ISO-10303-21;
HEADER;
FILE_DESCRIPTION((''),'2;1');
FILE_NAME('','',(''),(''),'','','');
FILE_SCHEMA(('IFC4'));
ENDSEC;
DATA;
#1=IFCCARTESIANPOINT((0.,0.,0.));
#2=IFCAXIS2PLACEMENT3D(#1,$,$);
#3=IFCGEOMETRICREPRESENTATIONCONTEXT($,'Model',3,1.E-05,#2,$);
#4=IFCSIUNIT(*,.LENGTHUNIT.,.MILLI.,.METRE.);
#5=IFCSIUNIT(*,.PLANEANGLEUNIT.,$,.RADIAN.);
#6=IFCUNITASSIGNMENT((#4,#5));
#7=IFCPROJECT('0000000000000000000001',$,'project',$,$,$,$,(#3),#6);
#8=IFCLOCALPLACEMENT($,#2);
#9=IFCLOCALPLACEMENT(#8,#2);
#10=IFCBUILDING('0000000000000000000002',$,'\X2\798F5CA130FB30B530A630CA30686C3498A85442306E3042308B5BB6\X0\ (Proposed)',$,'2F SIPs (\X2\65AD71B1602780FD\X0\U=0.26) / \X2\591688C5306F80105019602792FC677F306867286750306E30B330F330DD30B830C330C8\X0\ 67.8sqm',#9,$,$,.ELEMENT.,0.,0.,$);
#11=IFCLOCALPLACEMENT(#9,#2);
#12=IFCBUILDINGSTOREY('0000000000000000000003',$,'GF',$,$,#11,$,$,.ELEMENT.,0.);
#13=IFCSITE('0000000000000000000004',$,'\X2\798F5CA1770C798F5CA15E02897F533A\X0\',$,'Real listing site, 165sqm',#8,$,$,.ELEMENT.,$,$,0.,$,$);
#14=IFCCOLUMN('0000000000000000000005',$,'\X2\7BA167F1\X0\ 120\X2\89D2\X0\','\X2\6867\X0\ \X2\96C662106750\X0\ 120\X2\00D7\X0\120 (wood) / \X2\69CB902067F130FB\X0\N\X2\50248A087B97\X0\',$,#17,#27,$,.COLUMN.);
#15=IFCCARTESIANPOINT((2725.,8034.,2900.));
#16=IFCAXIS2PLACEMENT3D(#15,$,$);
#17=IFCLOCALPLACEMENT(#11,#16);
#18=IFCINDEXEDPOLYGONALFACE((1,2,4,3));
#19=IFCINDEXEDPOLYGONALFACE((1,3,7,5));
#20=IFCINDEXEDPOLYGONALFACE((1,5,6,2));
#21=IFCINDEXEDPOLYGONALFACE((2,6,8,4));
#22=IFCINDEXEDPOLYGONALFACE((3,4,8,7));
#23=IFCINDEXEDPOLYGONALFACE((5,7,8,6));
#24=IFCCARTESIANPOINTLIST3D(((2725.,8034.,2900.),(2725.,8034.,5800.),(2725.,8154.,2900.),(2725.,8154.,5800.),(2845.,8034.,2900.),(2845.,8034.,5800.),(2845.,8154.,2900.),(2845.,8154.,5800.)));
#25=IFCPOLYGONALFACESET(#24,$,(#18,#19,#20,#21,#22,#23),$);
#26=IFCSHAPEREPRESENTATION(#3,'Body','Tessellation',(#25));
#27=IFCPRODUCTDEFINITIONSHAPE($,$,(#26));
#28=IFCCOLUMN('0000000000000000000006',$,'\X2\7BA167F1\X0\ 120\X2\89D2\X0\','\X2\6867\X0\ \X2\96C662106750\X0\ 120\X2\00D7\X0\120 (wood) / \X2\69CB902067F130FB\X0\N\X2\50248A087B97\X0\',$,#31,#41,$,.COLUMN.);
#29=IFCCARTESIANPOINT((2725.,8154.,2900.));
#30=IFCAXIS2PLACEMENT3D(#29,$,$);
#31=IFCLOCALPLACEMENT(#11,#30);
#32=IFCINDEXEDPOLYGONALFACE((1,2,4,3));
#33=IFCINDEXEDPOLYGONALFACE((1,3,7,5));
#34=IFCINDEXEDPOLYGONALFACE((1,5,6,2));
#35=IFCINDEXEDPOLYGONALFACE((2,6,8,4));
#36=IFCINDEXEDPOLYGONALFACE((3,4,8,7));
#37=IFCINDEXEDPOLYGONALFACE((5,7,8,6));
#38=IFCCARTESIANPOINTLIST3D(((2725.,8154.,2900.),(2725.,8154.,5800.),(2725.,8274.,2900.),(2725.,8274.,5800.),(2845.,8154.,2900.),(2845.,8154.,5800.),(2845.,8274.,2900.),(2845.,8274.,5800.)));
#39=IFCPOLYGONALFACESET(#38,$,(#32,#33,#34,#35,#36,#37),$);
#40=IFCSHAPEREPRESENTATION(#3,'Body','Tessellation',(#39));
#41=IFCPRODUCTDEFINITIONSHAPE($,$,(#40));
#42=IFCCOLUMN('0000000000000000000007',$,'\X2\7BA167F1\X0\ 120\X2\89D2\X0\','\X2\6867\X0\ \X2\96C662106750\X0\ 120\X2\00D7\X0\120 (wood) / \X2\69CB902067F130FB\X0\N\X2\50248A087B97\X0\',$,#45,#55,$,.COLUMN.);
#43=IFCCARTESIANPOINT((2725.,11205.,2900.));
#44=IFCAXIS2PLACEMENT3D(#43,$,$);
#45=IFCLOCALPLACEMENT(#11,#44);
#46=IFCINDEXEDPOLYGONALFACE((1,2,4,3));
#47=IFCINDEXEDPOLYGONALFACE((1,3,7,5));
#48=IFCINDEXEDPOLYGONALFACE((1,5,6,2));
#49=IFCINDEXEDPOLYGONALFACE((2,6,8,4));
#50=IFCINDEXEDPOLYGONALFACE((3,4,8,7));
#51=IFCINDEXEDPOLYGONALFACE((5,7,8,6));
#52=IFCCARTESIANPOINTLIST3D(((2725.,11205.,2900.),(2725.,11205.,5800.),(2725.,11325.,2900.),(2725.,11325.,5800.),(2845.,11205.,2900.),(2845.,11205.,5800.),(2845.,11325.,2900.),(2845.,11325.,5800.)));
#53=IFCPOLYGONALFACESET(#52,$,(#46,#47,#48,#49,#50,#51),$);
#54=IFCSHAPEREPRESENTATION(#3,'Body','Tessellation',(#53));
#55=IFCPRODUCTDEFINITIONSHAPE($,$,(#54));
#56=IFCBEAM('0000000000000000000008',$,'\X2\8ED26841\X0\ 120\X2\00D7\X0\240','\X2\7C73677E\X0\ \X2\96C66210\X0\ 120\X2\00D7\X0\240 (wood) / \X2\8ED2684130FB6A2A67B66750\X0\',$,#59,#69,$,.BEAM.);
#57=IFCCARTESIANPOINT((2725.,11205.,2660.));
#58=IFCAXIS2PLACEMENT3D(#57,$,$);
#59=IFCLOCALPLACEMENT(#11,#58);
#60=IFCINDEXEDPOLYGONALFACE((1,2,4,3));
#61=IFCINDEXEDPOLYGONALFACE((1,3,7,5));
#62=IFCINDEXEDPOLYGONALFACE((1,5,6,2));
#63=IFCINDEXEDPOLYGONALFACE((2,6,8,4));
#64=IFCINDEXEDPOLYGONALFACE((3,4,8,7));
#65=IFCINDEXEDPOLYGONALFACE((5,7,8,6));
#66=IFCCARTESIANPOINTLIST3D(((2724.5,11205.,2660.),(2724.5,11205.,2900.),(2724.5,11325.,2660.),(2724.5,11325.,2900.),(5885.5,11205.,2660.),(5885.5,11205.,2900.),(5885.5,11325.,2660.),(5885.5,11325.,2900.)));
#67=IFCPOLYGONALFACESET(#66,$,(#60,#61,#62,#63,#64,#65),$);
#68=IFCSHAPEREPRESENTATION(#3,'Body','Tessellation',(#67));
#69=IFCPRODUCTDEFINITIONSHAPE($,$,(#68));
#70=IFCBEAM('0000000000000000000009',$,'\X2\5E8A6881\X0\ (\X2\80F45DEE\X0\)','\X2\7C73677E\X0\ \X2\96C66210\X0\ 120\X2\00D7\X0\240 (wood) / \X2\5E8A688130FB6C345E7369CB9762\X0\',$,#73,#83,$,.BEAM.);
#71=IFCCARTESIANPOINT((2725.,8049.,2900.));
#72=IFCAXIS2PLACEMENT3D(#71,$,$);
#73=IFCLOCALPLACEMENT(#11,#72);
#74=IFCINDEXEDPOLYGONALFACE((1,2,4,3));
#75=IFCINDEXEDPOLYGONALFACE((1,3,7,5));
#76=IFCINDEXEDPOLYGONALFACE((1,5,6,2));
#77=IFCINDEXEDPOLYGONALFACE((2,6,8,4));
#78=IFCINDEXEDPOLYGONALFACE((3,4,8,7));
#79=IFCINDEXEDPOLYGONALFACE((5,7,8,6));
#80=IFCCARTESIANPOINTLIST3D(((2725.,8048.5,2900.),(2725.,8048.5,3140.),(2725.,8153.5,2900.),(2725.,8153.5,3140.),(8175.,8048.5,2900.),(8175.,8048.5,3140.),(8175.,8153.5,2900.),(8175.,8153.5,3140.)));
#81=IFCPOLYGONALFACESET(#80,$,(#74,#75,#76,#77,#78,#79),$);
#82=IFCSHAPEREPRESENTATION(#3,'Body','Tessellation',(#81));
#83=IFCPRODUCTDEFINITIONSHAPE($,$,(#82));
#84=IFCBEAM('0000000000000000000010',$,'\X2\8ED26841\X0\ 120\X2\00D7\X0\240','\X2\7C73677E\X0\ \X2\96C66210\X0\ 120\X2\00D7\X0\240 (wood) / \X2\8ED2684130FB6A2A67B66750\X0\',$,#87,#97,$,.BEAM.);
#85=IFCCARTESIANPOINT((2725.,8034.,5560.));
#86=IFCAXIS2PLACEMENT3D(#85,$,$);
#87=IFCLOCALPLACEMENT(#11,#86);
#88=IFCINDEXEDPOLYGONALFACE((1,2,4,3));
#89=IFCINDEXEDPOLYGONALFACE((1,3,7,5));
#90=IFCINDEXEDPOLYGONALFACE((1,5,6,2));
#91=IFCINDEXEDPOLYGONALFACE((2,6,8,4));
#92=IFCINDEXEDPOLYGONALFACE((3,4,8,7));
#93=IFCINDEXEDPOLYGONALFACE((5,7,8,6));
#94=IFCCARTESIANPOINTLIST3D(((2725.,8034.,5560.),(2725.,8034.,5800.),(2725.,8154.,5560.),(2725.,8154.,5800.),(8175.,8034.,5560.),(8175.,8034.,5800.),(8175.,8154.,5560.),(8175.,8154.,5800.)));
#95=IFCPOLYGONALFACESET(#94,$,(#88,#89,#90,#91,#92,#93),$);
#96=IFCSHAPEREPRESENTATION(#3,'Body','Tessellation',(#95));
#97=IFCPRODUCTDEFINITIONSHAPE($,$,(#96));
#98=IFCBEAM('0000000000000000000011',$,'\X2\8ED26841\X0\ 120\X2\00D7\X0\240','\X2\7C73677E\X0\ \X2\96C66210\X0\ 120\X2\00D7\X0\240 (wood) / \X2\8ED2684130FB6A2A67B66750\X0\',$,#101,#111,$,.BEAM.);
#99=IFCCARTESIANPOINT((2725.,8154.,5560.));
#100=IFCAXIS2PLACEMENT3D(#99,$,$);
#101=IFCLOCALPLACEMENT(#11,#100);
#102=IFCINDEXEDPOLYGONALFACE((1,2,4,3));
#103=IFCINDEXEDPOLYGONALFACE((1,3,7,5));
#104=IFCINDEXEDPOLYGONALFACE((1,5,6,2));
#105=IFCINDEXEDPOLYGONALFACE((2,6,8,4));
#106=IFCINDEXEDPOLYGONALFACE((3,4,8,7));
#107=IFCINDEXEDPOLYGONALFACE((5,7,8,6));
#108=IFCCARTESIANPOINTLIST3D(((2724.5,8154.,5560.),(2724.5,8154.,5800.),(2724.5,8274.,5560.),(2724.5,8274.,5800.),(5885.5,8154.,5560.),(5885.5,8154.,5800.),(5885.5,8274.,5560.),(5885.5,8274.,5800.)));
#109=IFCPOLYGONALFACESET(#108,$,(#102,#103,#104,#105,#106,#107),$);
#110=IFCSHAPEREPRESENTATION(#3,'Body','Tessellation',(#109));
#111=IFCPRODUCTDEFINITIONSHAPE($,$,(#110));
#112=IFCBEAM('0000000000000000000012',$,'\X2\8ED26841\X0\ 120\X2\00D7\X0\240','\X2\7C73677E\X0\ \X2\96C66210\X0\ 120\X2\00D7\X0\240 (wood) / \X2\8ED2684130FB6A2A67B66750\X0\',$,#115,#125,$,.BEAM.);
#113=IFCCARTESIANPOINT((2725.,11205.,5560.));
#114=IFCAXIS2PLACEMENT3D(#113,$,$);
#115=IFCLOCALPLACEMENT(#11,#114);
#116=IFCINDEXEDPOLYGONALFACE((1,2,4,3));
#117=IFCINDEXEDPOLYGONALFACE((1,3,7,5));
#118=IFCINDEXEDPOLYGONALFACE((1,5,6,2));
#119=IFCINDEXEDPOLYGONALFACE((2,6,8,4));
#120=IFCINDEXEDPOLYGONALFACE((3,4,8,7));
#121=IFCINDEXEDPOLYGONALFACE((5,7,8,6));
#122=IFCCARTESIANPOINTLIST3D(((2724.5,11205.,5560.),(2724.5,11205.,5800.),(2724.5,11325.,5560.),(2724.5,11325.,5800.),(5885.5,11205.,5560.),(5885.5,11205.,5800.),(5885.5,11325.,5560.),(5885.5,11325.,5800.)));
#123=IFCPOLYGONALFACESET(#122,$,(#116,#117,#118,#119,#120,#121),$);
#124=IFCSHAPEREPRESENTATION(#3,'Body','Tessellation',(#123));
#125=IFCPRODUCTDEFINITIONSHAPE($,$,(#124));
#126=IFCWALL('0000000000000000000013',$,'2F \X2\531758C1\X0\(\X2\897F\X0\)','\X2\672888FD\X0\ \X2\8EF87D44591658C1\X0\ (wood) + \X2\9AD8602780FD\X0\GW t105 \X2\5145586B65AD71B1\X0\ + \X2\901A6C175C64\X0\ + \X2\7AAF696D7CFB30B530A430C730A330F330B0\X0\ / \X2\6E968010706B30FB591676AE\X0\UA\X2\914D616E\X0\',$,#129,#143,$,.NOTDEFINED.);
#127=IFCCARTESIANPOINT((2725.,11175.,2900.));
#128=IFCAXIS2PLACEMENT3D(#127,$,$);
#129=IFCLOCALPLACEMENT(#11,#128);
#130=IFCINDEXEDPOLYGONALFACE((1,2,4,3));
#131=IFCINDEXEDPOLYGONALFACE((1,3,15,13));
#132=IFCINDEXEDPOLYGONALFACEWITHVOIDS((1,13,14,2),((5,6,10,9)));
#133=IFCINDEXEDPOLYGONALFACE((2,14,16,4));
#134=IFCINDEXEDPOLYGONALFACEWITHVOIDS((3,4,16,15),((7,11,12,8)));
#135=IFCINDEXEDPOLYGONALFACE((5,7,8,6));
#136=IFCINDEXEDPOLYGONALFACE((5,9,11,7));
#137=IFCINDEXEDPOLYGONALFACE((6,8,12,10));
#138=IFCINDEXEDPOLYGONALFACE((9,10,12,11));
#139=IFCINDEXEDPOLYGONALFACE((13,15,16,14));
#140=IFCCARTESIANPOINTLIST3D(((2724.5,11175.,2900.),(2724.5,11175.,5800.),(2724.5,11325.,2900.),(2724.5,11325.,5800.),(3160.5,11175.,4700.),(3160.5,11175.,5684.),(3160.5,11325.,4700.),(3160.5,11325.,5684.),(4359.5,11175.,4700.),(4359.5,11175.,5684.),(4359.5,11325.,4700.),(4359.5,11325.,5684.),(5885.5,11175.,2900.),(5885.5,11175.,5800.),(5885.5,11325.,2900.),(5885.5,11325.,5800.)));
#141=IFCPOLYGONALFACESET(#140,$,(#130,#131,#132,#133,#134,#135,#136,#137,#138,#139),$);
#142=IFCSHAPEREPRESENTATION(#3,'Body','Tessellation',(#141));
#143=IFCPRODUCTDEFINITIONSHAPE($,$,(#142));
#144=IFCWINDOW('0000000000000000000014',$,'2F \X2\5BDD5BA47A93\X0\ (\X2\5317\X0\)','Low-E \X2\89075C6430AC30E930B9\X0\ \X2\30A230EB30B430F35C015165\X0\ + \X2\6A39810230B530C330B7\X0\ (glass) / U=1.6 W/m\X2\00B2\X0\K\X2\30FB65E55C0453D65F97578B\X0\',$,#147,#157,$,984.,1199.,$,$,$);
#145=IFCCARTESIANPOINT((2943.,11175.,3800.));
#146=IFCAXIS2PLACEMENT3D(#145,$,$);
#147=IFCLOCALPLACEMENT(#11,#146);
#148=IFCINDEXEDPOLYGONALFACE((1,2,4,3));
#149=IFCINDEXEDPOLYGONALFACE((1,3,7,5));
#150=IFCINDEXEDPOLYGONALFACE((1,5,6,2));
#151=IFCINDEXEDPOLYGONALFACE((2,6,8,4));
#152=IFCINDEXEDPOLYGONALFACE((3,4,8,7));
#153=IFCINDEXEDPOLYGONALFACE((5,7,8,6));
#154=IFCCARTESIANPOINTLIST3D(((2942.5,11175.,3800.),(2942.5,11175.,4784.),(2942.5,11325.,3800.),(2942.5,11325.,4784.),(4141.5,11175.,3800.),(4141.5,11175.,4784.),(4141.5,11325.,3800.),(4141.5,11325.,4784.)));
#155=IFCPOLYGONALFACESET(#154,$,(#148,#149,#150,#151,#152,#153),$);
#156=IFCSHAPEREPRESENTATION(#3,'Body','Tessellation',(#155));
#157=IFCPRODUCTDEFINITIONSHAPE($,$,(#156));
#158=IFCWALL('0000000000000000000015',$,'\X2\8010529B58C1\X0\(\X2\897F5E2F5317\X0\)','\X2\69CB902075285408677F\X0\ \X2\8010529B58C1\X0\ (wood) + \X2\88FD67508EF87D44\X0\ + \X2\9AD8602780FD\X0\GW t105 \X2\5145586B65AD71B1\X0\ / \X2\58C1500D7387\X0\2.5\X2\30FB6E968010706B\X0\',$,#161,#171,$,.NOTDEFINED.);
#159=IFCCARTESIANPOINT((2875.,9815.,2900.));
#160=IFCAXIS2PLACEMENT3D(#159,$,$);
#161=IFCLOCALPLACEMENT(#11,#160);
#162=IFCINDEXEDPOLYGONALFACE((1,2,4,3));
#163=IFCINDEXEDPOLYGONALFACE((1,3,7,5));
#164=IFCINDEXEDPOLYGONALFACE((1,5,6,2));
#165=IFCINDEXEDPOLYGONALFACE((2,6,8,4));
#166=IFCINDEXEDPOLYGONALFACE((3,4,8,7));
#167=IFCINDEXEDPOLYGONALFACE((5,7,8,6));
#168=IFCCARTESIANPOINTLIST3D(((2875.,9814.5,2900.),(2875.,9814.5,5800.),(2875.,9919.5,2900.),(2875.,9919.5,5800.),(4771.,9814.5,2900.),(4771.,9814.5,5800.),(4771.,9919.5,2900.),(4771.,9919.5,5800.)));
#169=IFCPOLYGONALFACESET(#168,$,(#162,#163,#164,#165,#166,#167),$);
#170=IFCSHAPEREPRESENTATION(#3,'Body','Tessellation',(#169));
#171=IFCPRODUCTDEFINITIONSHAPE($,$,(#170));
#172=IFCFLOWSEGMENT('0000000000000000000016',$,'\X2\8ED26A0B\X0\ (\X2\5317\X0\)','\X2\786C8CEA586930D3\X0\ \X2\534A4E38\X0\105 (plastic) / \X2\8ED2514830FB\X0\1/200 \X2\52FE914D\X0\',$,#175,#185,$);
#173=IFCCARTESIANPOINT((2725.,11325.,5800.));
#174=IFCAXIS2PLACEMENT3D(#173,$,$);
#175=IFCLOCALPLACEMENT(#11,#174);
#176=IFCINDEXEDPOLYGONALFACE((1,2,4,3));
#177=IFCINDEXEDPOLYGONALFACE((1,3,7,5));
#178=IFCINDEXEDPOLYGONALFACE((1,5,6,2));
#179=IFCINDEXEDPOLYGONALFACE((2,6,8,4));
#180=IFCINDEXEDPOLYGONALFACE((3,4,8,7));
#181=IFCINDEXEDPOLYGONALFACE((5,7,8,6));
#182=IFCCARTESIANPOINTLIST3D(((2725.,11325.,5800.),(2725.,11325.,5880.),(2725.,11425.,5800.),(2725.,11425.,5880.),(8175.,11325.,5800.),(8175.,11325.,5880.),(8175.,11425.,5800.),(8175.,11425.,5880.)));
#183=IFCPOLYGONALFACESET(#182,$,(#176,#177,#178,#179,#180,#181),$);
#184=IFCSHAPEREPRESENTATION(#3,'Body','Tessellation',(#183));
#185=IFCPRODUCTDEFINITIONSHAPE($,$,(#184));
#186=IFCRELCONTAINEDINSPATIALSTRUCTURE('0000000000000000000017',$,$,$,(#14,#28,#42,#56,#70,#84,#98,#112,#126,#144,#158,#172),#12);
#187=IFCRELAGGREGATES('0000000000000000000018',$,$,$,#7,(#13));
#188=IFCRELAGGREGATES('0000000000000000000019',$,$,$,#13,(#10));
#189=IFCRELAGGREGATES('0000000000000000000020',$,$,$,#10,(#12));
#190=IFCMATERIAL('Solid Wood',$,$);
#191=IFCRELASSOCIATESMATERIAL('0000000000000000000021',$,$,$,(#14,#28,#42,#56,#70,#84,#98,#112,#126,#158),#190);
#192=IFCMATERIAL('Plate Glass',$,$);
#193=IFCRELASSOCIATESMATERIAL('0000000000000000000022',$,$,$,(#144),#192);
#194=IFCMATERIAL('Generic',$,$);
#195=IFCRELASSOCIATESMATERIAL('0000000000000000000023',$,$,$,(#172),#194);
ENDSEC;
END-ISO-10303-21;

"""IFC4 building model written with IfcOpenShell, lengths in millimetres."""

from ifc_helpers import new_model, si_unit, frame, frame_2d, origin, place, context, project, spatial, rectangle, extrude, material, element, fill, save


model = new_model("IFC4")

# Units and contexts
model_context = context("Model", 3, precision=1e-05, world=origin())
ifc_project = project(units=[si_unit("LENGTHUNIT", "METRE", prefix="MILLI"), si_unit("PLANEANGLEUNIT", "RADIAN")], contexts=[model_context])

# Site, building, storey
site_placement = place(None, origin())
site = spatial("IfcSite", under=ifc_project, at=site_placement, Name="福岡県福岡市西区", ObjectType="Real listing site, 165sqm", CompositionType="ELEMENT", RefElevation=0.0)
building_placement = place(site_placement, origin())
building = spatial("IfcBuilding", under=site, at=building_placement, Name="福岡・サウナと水風呂のある家 (Proposed)", ObjectType="2F SIPs (断熱性能U=0.26) / 外装は耐候性鋼板と木材のコンポジット 67.8sqm", CompositionType="ELEMENT", ElevationOfRefHeight=0.0, ElevationOfTerrain=0.0)
storey_placement = place(building_placement, origin())
storey = spatial("IfcBuildingStorey", under=building, at=storey_placement, Name="GF", CompositionType="ELEMENT", Elevation=0.0)

# Columns
ifc_material_1 = material(Name="Solid Wood")
column_1_placement = place(storey_placement, frame((2725.0, 8034.0, 2900.0)))
element("IfcColumn", 1, at=column_1_placement, inside=storey, material=ifc_material_1, Name="管柱 120角", Description="桧 集成材 120×120 (wood) / 構造柱・N値計算", PredefinedType="COLUMN", context=model_context, shape_type="SweptSolid", body=[
    extrude(rectangle(XDim=120.0, YDim=120.0, at=frame_2d((60.0, 60.0))), frame((2725.0, 8034.0, 2900.0)), (0.0, 0.0, 1.0), 2900.0),
])
column_2_placement = place(storey_placement, frame((2725.0, 8154.0, 2900.0)))
element("IfcColumn", 2, at=column_2_placement, inside=storey, material=ifc_material_1, Name="管柱 120角", Description="桧 集成材 120×120 (wood) / 構造柱・N値計算", PredefinedType="COLUMN", context=model_context, shape_type="SweptSolid", body=[
    extrude(rectangle(XDim=120.0, YDim=120.0, at=frame_2d((60.0, 60.0))), frame((2725.0, 8154.0, 2900.0)), (0.0, 0.0, 1.0), 2900.0),
])
column_3_placement = place(storey_placement, frame((2725.0, 11205.0, 2900.0)))
element("IfcColumn", 3, at=column_3_placement, inside=storey, material=ifc_material_1, Name="管柱 120角", Description="桧 集成材 120×120 (wood) / 構造柱・N値計算", PredefinedType="COLUMN", context=model_context, shape_type="SweptSolid", body=[
    extrude(rectangle(XDim=120.0, YDim=120.0, at=frame_2d((60.0, 60.0))), frame((2725.0, 11205.0, 2900.0)), (0.0, 0.0, 1.0), 2900.0),
])

# Beams
beam_1_placement = place(storey_placement, frame((2725.0, 11205.0, 2660.0)))
element("IfcBeam", 4, at=beam_1_placement, inside=storey, material=ifc_material_1, Name="軒桁 120×240", Description="米松 集成 120×240 (wood) / 軒桁・横架材", PredefinedType="BEAM", context=model_context, shape_type="SweptSolid", body=[
    extrude(rectangle(XDim=3161.0, YDim=120.0, at=frame_2d((1580.0, 60.0))), frame((2725.0, 11205.0, 2660.0)), (0.0, 0.0, 1.0), 240.0),
])
beam_2_placement = place(storey_placement, frame((2725.0, 8049.0, 2900.0)))
element("IfcBeam", 5, at=beam_2_placement, inside=storey, material=ifc_material_1, Name="床梁 (胴差)", Description="米松 集成 120×240 (wood) / 床梁・水平構面", PredefinedType="BEAM", context=model_context, shape_type="SweptSolid", body=[
    extrude(rectangle(XDim=5450.0, YDim=105.0, at=frame_2d((2725.0, 52.0))), frame((2725.0, 8049.0, 2900.0)), (0.0, 0.0, 1.0), 240.0),
])
beam_3_placement = place(storey_placement, frame((2725.0, 8034.0, 5560.0)))
element("IfcBeam", 6, at=beam_3_placement, inside=storey, material=ifc_material_1, Name="軒桁 120×240", Description="米松 集成 120×240 (wood) / 軒桁・横架材", PredefinedType="BEAM", context=model_context, shape_type="SweptSolid", body=[
    extrude(rectangle(XDim=5450.0, YDim=120.0, at=frame_2d((2725.0, 60.0))), frame((2725.0, 8034.0, 5560.0)), (0.0, 0.0, 1.0), 240.0),
])
beam_4_placement = place(storey_placement, frame((2725.0, 8154.0, 5560.0)))
element("IfcBeam", 7, at=beam_4_placement, inside=storey, material=ifc_material_1, Name="軒桁 120×240", Description="米松 集成 120×240 (wood) / 軒桁・横架材", PredefinedType="BEAM", context=model_context, shape_type="SweptSolid", body=[
    extrude(rectangle(XDim=3161.0, YDim=120.0, at=frame_2d((1580.0, 60.0))), frame((2725.0, 8154.0, 5560.0)), (0.0, 0.0, 1.0), 240.0),
])
beam_5_placement = place(storey_placement, frame((2725.0, 11205.0, 5560.0)))
element("IfcBeam", 8, at=beam_5_placement, inside=storey, material=ifc_material_1, Name="軒桁 120×240", Description="米松 集成 120×240 (wood) / 軒桁・横架材", PredefinedType="BEAM", context=model_context, shape_type="SweptSolid", body=[
    extrude(rectangle(XDim=3161.0, YDim=120.0, at=frame_2d((1580.0, 60.0))), frame((2725.0, 11205.0, 5560.0)), (0.0, 0.0, 1.0), 240.0),
])

# Wall, opening, window
wall_1_placement = place(storey_placement, frame((2725.0, 11175.0, 2900.0)))
wall_1 = element("IfcWall", 9, at=wall_1_placement, inside=storey, material=ifc_material_1, Name="2F 北壁(西)", Description="木製 軸組外壁 (wood) + 高性能GW t105 充填断熱 + 通気層 + 窯業系サイディング / 準耐火・外皮UA配慮", PredefinedType="NOTDEFINED", context=model_context, shape_type="SweptSolid", body=[
    extrude(rectangle(XDim=3161.0, YDim=150.0, at=frame_2d((1580.0, 75.0))), frame((2725.0, 11175.0, 2900.0)), (0.0, 0.0, 1.0), 2900.0),
])
opening_placement = place(storey_placement, frame((2943.0, 11175.0, 3800.0)))
opening = element("IfcOpeningElement", 10, at=opening_placement, cuts=wall_1, PredefinedType="NOTDEFINED", context=model_context, shape_type="SweptSolid", body=[
    extrude(rectangle(XDim=1199.0, YDim=150.0, at=frame_2d((599.0, 75.0))), frame((2943.0, 11175.0, 3800.0)), (0.0, 0.0, 1.0), 984.0),
])
ifc_material_2 = material(Name="Plate Glass")
window_placement = place(storey_placement, frame((2943.0, 11175.0, 3800.0)))
window = element("IfcWindow", 11, at=window_placement, inside=storey, material=ifc_material_2, Name="2F 寝室窓 (北)", Description="Low-E 複層ガラス アルゴン封入 + 樹脂サッシ (glass) / U=1.6 W/m²K・日射取得型", OverallHeight=984.0, OverallWidth=1199.0, context=model_context, shape_type="SweptSolid", body=[
    extrude(rectangle(XDim=1199.0, YDim=150.0, at=frame_2d((599.0, 75.0))), frame((2943.0, 11175.0, 3800.0)), (0.0, 0.0, 1.0), 984.0),
])
fill(opening, window)

# Wall
wall_2_placement = place(storey_placement, frame((2875.0, 9815.0, 2900.0)))
element("IfcWall", 12, at=wall_2_placement, inside=storey, material=ifc_material_1, Name="耐力壁(西帯北)", Description="構造用合板 耐力壁 (wood) + 製材軸組 + 高性能GW t105 充填断熱 / 壁倍率2.5・準耐火", PredefinedType="NOTDEFINED", context=model_context, shape_type="SweptSolid", body=[
    extrude(rectangle(XDim=1896.0, YDim=105.0, at=frame_2d((948.0, 52.0))), frame((2875.0, 9815.0, 2900.0)), (0.0, 0.0, 1.0), 2900.0),
])

# Shared definitions
ifc_material_3 = material(Name="Generic")

# Flow segment
flow_segment_placement = place(storey_placement, frame((2725.0, 11325.0, 5800.0)))
element("IfcFlowSegment", 13, at=flow_segment_placement, inside=storey, material=ifc_material_3, Name="軒樋 (北)", Description="硬質塩ビ 半丸105 (plastic) / 軒先・1/200 勾配", context=model_context, shape_type="SweptSolid", body=[
    extrude(rectangle(XDim=5450.0, YDim=100.0, at=frame_2d((2725.0, 50.0))), frame((2725.0, 11325.0, 5800.0)), (0.0, 0.0, 1.0), 80.0),
])

save(model, "model.ifc")
